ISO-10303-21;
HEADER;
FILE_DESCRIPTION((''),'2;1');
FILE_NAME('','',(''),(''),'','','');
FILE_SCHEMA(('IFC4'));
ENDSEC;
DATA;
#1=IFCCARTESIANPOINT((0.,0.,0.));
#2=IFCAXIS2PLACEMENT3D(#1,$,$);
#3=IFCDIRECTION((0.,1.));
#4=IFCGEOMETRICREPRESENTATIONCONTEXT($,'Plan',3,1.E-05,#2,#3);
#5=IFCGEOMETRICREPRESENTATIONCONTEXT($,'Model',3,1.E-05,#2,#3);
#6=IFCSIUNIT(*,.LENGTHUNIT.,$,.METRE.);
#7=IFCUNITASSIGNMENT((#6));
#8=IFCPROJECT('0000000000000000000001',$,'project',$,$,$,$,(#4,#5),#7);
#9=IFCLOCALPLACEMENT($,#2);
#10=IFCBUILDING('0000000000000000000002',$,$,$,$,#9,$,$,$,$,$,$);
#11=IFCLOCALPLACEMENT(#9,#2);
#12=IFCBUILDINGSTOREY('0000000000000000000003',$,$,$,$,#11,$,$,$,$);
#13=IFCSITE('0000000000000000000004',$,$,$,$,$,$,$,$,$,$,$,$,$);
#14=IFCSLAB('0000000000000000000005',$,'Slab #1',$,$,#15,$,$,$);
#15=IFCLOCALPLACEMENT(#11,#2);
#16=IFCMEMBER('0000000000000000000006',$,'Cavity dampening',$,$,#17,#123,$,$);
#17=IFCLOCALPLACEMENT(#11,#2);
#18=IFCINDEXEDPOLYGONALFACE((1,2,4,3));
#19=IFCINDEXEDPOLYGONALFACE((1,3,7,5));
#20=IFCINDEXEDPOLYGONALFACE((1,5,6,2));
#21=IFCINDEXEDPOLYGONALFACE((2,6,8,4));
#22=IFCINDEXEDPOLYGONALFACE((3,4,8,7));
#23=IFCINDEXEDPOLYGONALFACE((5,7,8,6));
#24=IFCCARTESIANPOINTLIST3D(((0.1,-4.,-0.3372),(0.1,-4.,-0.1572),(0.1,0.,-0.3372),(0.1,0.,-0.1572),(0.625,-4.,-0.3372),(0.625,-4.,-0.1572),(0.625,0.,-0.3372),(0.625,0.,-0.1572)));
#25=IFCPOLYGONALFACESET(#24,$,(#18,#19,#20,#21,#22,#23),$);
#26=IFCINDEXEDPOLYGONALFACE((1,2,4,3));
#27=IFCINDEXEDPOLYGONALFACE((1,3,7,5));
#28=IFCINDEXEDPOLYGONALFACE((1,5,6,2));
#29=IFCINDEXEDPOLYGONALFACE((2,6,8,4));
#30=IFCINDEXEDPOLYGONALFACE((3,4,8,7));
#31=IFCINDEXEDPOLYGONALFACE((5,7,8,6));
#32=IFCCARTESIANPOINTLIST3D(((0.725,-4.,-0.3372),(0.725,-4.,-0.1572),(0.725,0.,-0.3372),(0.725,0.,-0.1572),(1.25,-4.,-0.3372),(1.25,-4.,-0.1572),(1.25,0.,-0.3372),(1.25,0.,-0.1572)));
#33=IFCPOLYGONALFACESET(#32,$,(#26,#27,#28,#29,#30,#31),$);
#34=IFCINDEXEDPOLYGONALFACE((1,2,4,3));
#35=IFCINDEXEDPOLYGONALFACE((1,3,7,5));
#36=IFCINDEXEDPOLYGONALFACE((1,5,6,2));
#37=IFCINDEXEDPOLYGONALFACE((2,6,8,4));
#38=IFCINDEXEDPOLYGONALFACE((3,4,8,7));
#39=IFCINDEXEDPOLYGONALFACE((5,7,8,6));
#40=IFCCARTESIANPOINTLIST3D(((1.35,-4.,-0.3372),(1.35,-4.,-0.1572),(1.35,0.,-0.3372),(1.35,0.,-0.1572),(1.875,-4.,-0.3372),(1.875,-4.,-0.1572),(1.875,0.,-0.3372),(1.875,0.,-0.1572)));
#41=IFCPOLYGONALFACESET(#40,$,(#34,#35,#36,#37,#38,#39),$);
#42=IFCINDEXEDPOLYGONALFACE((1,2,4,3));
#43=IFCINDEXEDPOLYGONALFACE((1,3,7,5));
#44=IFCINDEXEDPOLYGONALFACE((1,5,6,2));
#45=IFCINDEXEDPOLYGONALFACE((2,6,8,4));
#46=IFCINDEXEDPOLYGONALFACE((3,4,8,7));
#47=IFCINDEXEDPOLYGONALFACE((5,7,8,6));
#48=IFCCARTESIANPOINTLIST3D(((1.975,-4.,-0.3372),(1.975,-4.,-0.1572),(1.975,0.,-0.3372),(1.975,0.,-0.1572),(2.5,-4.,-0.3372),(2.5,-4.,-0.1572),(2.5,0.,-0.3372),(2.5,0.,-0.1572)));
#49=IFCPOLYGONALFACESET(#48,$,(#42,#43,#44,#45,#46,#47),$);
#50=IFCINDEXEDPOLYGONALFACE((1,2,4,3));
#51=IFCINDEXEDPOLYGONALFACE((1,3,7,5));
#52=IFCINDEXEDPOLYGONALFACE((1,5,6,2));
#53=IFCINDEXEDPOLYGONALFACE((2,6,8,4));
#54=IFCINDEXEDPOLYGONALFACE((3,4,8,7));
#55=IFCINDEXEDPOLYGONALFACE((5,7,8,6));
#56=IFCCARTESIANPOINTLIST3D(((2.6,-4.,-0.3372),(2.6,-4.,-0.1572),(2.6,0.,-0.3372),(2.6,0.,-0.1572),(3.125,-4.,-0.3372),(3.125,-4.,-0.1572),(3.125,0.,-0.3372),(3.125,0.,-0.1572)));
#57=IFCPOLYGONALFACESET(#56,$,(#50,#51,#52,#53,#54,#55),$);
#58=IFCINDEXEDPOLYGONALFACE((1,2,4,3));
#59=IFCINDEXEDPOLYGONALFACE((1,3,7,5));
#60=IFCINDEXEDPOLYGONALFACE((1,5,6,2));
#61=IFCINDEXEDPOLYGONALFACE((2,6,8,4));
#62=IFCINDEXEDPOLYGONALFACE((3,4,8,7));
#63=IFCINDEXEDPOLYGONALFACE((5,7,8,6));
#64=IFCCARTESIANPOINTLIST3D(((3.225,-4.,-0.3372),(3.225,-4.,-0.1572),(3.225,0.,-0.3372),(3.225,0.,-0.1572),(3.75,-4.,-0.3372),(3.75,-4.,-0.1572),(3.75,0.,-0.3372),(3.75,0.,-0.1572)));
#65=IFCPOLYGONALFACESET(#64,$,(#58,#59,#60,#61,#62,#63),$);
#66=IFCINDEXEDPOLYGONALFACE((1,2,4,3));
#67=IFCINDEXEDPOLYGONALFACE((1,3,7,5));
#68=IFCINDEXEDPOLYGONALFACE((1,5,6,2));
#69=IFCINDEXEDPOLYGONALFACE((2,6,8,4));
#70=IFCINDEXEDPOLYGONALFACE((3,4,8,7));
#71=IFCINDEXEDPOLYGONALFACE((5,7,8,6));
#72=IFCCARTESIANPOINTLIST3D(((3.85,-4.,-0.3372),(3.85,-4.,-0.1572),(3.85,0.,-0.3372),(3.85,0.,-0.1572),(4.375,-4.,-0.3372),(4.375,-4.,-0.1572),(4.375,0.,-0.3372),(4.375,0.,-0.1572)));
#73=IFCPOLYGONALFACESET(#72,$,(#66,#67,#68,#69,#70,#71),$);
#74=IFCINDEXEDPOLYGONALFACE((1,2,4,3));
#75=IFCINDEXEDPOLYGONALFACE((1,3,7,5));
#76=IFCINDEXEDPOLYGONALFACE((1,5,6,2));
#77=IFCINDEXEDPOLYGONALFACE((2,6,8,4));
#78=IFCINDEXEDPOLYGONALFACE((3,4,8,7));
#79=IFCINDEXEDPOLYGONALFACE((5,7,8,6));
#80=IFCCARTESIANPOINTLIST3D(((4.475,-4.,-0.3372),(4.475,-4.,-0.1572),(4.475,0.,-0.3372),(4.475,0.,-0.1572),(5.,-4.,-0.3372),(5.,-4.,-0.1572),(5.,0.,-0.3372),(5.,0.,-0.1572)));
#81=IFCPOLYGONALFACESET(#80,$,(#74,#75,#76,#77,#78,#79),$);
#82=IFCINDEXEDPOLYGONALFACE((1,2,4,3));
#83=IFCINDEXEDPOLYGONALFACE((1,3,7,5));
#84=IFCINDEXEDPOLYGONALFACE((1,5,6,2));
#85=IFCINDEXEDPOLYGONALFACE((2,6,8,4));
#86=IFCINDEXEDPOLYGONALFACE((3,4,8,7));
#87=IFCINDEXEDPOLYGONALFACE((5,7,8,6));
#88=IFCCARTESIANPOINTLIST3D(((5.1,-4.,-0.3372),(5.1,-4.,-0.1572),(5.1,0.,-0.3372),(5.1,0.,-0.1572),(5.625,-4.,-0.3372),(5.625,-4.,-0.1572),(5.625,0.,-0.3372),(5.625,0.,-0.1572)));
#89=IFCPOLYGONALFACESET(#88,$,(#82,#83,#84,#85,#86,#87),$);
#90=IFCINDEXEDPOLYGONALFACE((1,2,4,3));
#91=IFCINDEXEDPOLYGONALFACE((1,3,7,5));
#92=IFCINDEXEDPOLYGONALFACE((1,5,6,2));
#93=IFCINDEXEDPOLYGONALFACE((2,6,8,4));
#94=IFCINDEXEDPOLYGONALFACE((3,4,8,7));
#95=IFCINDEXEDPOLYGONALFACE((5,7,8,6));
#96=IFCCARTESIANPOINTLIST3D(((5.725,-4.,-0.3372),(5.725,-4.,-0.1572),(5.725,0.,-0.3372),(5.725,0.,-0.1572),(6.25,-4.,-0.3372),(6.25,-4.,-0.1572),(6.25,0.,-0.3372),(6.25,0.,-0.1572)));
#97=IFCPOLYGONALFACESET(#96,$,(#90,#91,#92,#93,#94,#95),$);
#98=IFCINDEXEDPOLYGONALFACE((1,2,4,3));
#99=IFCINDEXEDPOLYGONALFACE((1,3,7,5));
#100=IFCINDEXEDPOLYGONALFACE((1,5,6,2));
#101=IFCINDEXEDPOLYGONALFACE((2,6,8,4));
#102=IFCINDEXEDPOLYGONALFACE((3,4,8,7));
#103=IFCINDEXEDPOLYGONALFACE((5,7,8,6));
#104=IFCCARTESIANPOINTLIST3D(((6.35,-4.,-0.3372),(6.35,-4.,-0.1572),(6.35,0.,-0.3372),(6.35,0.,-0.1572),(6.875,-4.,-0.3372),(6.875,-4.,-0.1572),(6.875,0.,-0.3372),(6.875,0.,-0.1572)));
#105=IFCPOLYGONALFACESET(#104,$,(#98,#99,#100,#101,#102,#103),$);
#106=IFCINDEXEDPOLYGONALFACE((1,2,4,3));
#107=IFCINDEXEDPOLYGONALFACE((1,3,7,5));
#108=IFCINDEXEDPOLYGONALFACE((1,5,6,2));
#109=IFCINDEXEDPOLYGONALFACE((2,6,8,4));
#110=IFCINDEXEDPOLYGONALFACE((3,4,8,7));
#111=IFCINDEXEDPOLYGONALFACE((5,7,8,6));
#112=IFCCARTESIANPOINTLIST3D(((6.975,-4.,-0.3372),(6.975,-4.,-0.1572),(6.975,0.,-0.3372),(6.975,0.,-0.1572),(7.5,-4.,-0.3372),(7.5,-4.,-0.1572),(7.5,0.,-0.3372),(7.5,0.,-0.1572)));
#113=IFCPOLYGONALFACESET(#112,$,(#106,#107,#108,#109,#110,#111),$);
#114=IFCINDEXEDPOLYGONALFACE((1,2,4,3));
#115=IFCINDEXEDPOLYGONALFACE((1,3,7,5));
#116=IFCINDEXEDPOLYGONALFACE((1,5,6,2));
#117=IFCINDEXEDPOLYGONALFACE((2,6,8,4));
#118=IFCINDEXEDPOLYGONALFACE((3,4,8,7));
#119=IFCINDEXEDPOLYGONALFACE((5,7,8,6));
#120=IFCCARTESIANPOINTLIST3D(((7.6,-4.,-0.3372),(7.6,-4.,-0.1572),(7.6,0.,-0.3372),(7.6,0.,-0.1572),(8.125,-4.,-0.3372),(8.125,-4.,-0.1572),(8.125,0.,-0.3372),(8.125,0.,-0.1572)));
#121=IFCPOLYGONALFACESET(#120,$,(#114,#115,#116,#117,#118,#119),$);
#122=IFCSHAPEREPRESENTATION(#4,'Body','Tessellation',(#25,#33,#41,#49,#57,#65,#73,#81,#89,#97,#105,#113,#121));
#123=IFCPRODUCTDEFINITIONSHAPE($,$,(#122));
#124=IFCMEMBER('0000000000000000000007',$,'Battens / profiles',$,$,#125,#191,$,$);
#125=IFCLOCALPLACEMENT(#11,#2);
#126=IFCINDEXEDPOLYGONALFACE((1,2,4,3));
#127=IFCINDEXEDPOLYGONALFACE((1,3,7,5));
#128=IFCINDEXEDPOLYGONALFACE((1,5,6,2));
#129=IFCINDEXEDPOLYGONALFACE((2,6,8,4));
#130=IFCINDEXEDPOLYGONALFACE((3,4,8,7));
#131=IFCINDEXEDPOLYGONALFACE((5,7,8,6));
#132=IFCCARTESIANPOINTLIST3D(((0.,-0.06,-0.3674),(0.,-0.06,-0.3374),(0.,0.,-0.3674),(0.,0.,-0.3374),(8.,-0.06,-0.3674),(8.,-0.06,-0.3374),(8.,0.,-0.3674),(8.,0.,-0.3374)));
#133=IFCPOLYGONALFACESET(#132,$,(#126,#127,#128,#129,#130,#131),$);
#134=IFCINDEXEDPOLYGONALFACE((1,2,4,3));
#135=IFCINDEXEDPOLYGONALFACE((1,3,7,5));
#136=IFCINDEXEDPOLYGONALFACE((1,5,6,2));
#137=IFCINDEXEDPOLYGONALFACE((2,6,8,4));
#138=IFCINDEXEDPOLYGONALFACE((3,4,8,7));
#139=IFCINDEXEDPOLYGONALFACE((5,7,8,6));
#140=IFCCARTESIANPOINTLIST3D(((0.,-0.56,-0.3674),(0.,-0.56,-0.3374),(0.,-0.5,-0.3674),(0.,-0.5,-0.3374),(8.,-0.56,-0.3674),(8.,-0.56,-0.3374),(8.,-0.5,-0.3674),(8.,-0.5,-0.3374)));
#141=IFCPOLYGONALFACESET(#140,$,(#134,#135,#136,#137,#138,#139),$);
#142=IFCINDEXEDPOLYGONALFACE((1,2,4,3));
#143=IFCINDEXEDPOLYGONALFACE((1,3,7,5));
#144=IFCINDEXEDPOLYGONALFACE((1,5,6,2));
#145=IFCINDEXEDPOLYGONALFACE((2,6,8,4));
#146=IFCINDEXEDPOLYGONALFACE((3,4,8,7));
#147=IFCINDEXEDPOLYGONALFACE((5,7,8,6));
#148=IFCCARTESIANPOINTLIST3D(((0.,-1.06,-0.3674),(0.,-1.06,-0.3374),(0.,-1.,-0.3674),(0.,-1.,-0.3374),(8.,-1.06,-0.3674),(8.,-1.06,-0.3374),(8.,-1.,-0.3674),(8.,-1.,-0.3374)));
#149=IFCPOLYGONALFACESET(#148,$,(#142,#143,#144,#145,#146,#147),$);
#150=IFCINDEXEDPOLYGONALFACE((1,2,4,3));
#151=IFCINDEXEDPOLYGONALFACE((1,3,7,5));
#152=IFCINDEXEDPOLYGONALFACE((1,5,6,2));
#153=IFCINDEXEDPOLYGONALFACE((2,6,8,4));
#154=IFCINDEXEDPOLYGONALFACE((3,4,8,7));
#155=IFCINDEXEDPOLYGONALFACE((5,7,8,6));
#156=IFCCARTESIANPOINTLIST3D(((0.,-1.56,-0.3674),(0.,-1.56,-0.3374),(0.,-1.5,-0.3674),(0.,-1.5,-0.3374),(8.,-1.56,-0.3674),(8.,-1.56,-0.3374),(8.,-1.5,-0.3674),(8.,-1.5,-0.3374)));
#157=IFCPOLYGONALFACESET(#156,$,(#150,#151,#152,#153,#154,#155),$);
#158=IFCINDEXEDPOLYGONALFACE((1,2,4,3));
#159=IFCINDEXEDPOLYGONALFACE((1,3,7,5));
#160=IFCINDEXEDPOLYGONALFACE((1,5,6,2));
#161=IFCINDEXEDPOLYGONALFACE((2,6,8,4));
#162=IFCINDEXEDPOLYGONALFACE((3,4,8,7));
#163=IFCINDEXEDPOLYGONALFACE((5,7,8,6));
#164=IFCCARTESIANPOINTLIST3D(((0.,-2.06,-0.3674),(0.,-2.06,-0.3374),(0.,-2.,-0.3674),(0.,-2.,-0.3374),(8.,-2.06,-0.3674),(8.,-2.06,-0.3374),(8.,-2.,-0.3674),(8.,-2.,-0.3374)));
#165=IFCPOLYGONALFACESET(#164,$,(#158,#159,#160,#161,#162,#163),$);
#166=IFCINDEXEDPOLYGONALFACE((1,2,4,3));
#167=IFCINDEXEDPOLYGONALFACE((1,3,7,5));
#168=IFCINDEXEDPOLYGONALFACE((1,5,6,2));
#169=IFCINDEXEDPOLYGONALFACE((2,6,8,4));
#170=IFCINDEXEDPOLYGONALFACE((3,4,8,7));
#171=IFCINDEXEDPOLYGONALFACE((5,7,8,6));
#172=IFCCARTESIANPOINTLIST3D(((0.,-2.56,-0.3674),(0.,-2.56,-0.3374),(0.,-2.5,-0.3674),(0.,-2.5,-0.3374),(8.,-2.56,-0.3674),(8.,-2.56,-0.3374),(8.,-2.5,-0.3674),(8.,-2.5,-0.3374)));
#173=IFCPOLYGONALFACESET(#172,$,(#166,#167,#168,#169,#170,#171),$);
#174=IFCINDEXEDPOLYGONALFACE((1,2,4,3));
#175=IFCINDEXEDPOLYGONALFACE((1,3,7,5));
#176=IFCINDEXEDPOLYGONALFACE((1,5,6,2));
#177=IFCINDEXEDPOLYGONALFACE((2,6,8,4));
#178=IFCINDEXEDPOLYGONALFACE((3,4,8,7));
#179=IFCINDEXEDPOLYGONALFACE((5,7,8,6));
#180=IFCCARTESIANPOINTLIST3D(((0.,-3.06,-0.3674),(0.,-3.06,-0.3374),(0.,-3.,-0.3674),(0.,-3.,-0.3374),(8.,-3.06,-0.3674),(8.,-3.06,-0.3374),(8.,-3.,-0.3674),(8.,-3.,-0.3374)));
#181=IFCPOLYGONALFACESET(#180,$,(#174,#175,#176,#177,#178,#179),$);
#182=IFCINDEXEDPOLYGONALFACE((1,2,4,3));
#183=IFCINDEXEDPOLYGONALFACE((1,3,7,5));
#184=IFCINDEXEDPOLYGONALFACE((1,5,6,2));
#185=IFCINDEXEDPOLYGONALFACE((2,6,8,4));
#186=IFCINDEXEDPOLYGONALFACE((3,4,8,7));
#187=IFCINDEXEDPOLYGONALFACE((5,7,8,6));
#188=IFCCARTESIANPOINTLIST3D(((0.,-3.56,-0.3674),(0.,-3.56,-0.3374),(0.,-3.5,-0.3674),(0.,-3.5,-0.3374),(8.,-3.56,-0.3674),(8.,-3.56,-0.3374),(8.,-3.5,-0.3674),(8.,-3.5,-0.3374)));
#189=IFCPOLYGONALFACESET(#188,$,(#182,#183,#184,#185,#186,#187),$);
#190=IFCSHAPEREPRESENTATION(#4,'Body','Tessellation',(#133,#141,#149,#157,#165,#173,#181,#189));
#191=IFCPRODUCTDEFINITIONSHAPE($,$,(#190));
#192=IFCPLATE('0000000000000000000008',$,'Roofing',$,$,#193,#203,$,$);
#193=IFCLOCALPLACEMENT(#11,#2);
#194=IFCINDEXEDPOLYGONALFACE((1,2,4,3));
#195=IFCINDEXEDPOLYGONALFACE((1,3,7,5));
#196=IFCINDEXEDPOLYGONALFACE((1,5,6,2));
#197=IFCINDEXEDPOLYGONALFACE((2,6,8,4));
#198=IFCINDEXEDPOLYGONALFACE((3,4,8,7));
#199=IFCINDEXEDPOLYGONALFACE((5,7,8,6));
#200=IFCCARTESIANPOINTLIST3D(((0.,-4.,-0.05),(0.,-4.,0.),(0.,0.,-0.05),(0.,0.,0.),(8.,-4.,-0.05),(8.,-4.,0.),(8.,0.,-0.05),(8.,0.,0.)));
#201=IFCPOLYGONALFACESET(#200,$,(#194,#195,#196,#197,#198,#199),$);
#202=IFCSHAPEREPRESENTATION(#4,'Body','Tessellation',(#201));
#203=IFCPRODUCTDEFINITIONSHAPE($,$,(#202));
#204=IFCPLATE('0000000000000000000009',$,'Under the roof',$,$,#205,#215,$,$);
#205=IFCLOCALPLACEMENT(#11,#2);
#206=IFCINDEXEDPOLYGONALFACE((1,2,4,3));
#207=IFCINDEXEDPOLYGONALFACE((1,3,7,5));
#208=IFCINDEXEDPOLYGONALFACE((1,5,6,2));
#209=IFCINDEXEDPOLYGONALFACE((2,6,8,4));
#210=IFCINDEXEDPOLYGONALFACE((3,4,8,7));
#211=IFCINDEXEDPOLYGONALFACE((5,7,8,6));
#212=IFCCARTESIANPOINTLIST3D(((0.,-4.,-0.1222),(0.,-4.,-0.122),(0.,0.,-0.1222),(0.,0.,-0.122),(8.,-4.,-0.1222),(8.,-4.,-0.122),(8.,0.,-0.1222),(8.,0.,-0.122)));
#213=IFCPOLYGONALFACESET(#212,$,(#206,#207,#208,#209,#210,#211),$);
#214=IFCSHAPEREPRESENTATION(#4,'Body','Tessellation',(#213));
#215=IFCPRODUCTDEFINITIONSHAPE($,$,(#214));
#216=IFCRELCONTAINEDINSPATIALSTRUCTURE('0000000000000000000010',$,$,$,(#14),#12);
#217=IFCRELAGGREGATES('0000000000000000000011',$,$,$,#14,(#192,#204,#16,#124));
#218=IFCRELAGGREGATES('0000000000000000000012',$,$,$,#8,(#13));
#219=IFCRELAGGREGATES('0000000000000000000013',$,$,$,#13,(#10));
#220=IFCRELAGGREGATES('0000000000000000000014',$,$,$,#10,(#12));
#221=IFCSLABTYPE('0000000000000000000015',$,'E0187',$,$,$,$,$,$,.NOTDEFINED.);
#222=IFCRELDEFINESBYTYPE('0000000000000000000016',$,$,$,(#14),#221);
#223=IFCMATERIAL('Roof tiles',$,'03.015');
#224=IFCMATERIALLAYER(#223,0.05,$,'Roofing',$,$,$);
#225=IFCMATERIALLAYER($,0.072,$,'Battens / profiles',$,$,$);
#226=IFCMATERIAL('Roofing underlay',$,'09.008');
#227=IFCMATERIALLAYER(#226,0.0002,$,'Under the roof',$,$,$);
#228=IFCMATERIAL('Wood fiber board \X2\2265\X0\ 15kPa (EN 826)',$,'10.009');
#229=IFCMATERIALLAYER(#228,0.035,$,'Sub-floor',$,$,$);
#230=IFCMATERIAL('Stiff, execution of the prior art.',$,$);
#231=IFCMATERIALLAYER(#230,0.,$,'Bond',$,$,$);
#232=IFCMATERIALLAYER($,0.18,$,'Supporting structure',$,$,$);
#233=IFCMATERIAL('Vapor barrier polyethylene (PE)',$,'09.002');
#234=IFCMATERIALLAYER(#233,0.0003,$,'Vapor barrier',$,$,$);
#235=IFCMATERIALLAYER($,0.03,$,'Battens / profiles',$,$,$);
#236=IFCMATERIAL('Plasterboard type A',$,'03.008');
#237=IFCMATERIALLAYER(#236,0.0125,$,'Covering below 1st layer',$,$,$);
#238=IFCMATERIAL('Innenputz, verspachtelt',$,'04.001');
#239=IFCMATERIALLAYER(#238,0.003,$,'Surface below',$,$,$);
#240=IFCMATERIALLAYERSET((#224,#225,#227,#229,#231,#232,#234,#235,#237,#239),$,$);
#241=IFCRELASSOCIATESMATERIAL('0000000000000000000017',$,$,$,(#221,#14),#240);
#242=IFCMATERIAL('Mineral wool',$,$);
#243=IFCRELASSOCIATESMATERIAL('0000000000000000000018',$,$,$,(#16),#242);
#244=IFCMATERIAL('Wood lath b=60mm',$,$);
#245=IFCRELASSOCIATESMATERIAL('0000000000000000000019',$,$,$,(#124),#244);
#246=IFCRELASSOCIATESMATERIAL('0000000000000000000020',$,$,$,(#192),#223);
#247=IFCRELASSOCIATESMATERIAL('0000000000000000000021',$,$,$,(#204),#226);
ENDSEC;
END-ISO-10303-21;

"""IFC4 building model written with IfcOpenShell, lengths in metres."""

from ifc_helpers import new_model, si_unit, direction, frame, frame_2d, origin, origin_with_axes, place, context, project, spatial, rectangle, extrude, material, layer, layer_set, type_object, element, aggregate, save


model = new_model("IFC4")

# Units and contexts
plan_context = context("Plan", 3, precision=1e-05, world=origin(), true_north=direction((0.0, 1.0)))
model_context = context("Model", 3, precision=1e-05, world=origin(), true_north=direction((0.0, 1.0)))
ifc_project = project(units=[si_unit("LENGTHUNIT", "METRE")], contexts=[plan_context, model_context])

# Site, building, storey
site = spatial("IfcSite", under=ifc_project)
building_placement = place(None, origin())
building = spatial("IfcBuilding", under=site, at=building_placement)
storey_placement = place(building_placement, origin())
storey = spatial("IfcBuildingStorey", under=building, at=storey_placement)

# Slab, members, plates
ifc_material_1 = material(Name="Roof tiles", Category="03.015")
ifc_layer_1 = layer(ifc_material_1, 0.05, Name="Roofing")
ifc_layer_2 = layer(None, 0.072, Name="Battens / profiles")
ifc_material_2 = material(Name="Roofing underlay", Category="09.008")
ifc_layer_3 = layer(ifc_material_2, 0.0002, Name="Under the roof")
ifc_material_3 = material(Name="Wood fiber board ≥ 15kPa (EN 826)", Category="10.009")
ifc_layer_4 = layer(ifc_material_3, 0.035, Name="Sub-floor")
ifc_material_4 = material(Name="Stiff, execution of the prior art.")
ifc_layer_5 = layer(ifc_material_4, 0.0, Name="Bond")
ifc_layer_6 = layer(None, 0.18, Name="Supporting structure")
ifc_material_5 = material(Name="Vapor barrier polyethylene (PE)", Category="09.002")
ifc_layer_7 = layer(ifc_material_5, 0.0003, Name="Vapor barrier")
ifc_layer_8 = layer(None, 0.03, Name="Battens / profiles")
ifc_material_6 = material(Name="Plasterboard type A", Category="03.008")
ifc_layer_9 = layer(ifc_material_6, 0.0125, Name="Covering below 1st layer")
ifc_material_7 = material(Name="Innenputz, verspachtelt", Category="04.001")
ifc_layer_10 = layer(ifc_material_7, 0.003, Name="Surface below")
ifc_layer_set = layer_set([ifc_layer_1, ifc_layer_2, ifc_layer_3, ifc_layer_4, ifc_layer_5, ifc_layer_6, ifc_layer_7, ifc_layer_8, ifc_layer_9, ifc_layer_10])
slab_type = type_object("IfcSlabType", Name="E0187", PredefinedType="NOTDEFINED", material=ifc_layer_set)
slab_placement = place(None, frame((0.0, 0.0, 0.0), z_axis=(0.0, 0.0, -1.0), x_axis=(1.0, 0.0, 0.0)))
slab = element("IfcSlab", 1, at=slab_placement, inside=storey, type_object=slab_type, material=ifc_layer_set, Name="Slab #1")
ifc_material_8 = material(Name="Mineral wool")
member_1_placement = place(slab_placement, origin())
member_1 = element("IfcMember", 2, at=member_1_placement, material=ifc_material_8, Name="Cavity dampening", context=plan_context, shape_type="SweptSolid", body=[
    extrude(rectangle(XDim=0.525, YDim=0.18, at=frame_2d((0.2625, 0.09), x_axis=(1.0, 0.0))), frame((0.1, 4.0, 0.1572), z_axis=(0.0, -1.0, 0.0), x_axis=(1.0, 0.0, 0.0)), (0.0, 0.0, 1.0), 4.0),
    extrude(rectangle(XDim=0.525, YDim=0.18, at=frame_2d((0.2625, 0.09), x_axis=(1.0, 0.0))), frame((0.725, 4.0, 0.1572), z_axis=(0.0, -1.0, 0.0), x_axis=(1.0, 0.0, 0.0)), (0.0, 0.0, 1.0), 4.0),
    extrude(rectangle(XDim=0.525, YDim=0.18, at=frame_2d((0.2625, 0.09), x_axis=(1.0, 0.0))), frame((1.35, 4.0, 0.1572), z_axis=(0.0, -1.0, 0.0), x_axis=(1.0, 0.0, 0.0)), (0.0, 0.0, 1.0), 4.0),
    extrude(rectangle(XDim=0.525, YDim=0.18, at=frame_2d((0.2625, 0.09), x_axis=(1.0, 0.0))), frame((1.975, 4.0, 0.1572), z_axis=(0.0, -1.0, 0.0), x_axis=(1.0, 0.0, 0.0)), (0.0, 0.0, 1.0), 4.0),
    extrude(rectangle(XDim=0.525, YDim=0.18, at=frame_2d((0.2625, 0.09), x_axis=(1.0, 0.0))), frame((2.6, 4.0, 0.1572), z_axis=(0.0, -1.0, 0.0), x_axis=(1.0, 0.0, 0.0)), (0.0, 0.0, 1.0), 4.0),
    extrude(rectangle(XDim=0.525, YDim=0.18, at=frame_2d((0.2625, 0.09), x_axis=(1.0, 0.0))), frame((3.225, 4.0, 0.1572), z_axis=(0.0, -1.0, 0.0), x_axis=(1.0, 0.0, 0.0)), (0.0, 0.0, 1.0), 4.0),
    extrude(rectangle(XDim=0.525, YDim=0.18, at=frame_2d((0.2625, 0.09), x_axis=(1.0, 0.0))), frame((3.85, 4.0, 0.1572), z_axis=(0.0, -1.0, 0.0), x_axis=(1.0, 0.0, 0.0)), (0.0, 0.0, 1.0), 4.0),
    extrude(rectangle(XDim=0.525, YDim=0.18, at=frame_2d((0.2625, 0.09), x_axis=(1.0, 0.0))), frame((4.475, 4.0, 0.1572), z_axis=(0.0, -1.0, 0.0), x_axis=(1.0, 0.0, 0.0)), (0.0, 0.0, 1.0), 4.0),
    extrude(rectangle(XDim=0.525, YDim=0.18, at=frame_2d((0.2625, 0.09), x_axis=(1.0, 0.0))), frame((5.1, 4.0, 0.1572), z_axis=(0.0, -1.0, 0.0), x_axis=(1.0, 0.0, 0.0)), (0.0, 0.0, 1.0), 4.0),
    extrude(rectangle(XDim=0.525, YDim=0.18, at=frame_2d((0.2625, 0.09), x_axis=(1.0, 0.0))), frame((5.725, 4.0, 0.1572), z_axis=(0.0, -1.0, 0.0), x_axis=(1.0, 0.0, 0.0)), (0.0, 0.0, 1.0), 4.0),
    extrude(rectangle(XDim=0.525, YDim=0.18, at=frame_2d((0.2625, 0.09), x_axis=(1.0, 0.0))), frame((6.35, 4.0, 0.1572), z_axis=(0.0, -1.0, 0.0), x_axis=(1.0, 0.0, 0.0)), (0.0, 0.0, 1.0), 4.0),
    extrude(rectangle(XDim=0.525, YDim=0.18, at=frame_2d((0.2625, 0.09), x_axis=(1.0, 0.0))), frame((6.975, 4.0, 0.1572), z_axis=(0.0, -1.0, 0.0), x_axis=(1.0, 0.0, 0.0)), (0.0, 0.0, 1.0), 4.0),
    extrude(rectangle(XDim=0.525, YDim=0.18, at=frame_2d((0.2625, 0.09), x_axis=(1.0, 0.0))), frame((7.6, 4.0, 0.1572), z_axis=(0.0, -1.0, 0.0), x_axis=(1.0, 0.0, 0.0)), (0.0, 0.0, 1.0), 4.0),
])
ifc_material_9 = material(Name="Wood lath b=60mm")
member_2_placement = place(slab_placement, origin())
member_2 = element("IfcMember", 3, at=member_2_placement, material=ifc_material_9, Name="Battens / profiles", context=plan_context, shape_type="SweptSolid", body=[
    extrude(rectangle(XDim=0.06, YDim=0.03, at=frame_2d((0.03, 0.015), x_axis=(1.0, 0.0))), frame((0.0, 0.0, 0.3374), z_axis=(1.0, 0.0, 0.0), x_axis=(0.0, 1.0, 0.0)), (0.0, 0.0, 1.0), 8.0),
    extrude(rectangle(XDim=0.06, YDim=0.03, at=frame_2d((0.03, 0.015), x_axis=(1.0, 0.0))), frame((0.0, 0.5, 0.3374), z_axis=(1.0, 0.0, 0.0), x_axis=(0.0, 1.0, 0.0)), (0.0, 0.0, 1.0), 8.0),
    extrude(rectangle(XDim=0.06, YDim=0.03, at=frame_2d((0.03, 0.015), x_axis=(1.0, 0.0))), frame((0.0, 1.0, 0.3374), z_axis=(1.0, 0.0, 0.0), x_axis=(0.0, 1.0, 0.0)), (0.0, 0.0, 1.0), 8.0),
    extrude(rectangle(XDim=0.06, YDim=0.03, at=frame_2d((0.03, 0.015), x_axis=(1.0, 0.0))), frame((0.0, 1.5, 0.3374), z_axis=(1.0, 0.0, 0.0), x_axis=(0.0, 1.0, 0.0)), (0.0, 0.0, 1.0), 8.0),
    extrude(rectangle(XDim=0.06, YDim=0.03, at=frame_2d((0.03, 0.015), x_axis=(1.0, 0.0))), frame((0.0, 2.0, 0.3374), z_axis=(1.0, 0.0, 0.0), x_axis=(0.0, 1.0, 0.0)), (0.0, 0.0, 1.0), 8.0),
    extrude(rectangle(XDim=0.06, YDim=0.03, at=frame_2d((0.03, 0.015), x_axis=(1.0, 0.0))), frame((0.0, 2.5, 0.3374), z_axis=(1.0, 0.0, 0.0), x_axis=(0.0, 1.0, 0.0)), (0.0, 0.0, 1.0), 8.0),
    extrude(rectangle(XDim=0.06, YDim=0.03, at=frame_2d((0.03, 0.015), x_axis=(1.0, 0.0))), frame((0.0, 3.0, 0.3374), z_axis=(1.0, 0.0, 0.0), x_axis=(0.0, 1.0, 0.0)), (0.0, 0.0, 1.0), 8.0),
    extrude(rectangle(XDim=0.06, YDim=0.03, at=frame_2d((0.03, 0.015), x_axis=(1.0, 0.0))), frame((0.0, 3.5, 0.3374), z_axis=(1.0, 0.0, 0.0), x_axis=(0.0, 1.0, 0.0)), (0.0, 0.0, 1.0), 8.0),
])
plate_1_placement = place(slab_placement, origin())
plate_1 = element("IfcPlate", 4, at=plate_1_placement, material=ifc_material_1, Name="Roofing", context=plan_context, shape_type="SweptSolid", body=[
    extrude(rectangle(XDim=8.0, YDim=4.0, at=frame_2d((4.0, 2.0), x_axis=(1.0, 0.0))), origin_with_axes(), (0.0, 0.0, 1.0), 0.05),
])
plate_2_placement = place(slab_placement, origin())
plate_2 = element("IfcPlate", 5, at=plate_2_placement, material=ifc_material_2, Name="Under the roof", context=plan_context, shape_type="SweptSolid", body=[
    extrude(rectangle(XDim=8.0, YDim=4.0, at=frame_2d((4.0, 2.0), x_axis=(1.0, 0.0))), frame((0.0, 0.0, 0.122), z_axis=(0.0, 0.0, 1.0), x_axis=(1.0, 0.0, 0.0)), (0.0, 0.0, 1.0), 0.0002),
])
aggregate(slab, [plate_1, plate_2, member_1, member_2])

save(model, "model.ifc")
